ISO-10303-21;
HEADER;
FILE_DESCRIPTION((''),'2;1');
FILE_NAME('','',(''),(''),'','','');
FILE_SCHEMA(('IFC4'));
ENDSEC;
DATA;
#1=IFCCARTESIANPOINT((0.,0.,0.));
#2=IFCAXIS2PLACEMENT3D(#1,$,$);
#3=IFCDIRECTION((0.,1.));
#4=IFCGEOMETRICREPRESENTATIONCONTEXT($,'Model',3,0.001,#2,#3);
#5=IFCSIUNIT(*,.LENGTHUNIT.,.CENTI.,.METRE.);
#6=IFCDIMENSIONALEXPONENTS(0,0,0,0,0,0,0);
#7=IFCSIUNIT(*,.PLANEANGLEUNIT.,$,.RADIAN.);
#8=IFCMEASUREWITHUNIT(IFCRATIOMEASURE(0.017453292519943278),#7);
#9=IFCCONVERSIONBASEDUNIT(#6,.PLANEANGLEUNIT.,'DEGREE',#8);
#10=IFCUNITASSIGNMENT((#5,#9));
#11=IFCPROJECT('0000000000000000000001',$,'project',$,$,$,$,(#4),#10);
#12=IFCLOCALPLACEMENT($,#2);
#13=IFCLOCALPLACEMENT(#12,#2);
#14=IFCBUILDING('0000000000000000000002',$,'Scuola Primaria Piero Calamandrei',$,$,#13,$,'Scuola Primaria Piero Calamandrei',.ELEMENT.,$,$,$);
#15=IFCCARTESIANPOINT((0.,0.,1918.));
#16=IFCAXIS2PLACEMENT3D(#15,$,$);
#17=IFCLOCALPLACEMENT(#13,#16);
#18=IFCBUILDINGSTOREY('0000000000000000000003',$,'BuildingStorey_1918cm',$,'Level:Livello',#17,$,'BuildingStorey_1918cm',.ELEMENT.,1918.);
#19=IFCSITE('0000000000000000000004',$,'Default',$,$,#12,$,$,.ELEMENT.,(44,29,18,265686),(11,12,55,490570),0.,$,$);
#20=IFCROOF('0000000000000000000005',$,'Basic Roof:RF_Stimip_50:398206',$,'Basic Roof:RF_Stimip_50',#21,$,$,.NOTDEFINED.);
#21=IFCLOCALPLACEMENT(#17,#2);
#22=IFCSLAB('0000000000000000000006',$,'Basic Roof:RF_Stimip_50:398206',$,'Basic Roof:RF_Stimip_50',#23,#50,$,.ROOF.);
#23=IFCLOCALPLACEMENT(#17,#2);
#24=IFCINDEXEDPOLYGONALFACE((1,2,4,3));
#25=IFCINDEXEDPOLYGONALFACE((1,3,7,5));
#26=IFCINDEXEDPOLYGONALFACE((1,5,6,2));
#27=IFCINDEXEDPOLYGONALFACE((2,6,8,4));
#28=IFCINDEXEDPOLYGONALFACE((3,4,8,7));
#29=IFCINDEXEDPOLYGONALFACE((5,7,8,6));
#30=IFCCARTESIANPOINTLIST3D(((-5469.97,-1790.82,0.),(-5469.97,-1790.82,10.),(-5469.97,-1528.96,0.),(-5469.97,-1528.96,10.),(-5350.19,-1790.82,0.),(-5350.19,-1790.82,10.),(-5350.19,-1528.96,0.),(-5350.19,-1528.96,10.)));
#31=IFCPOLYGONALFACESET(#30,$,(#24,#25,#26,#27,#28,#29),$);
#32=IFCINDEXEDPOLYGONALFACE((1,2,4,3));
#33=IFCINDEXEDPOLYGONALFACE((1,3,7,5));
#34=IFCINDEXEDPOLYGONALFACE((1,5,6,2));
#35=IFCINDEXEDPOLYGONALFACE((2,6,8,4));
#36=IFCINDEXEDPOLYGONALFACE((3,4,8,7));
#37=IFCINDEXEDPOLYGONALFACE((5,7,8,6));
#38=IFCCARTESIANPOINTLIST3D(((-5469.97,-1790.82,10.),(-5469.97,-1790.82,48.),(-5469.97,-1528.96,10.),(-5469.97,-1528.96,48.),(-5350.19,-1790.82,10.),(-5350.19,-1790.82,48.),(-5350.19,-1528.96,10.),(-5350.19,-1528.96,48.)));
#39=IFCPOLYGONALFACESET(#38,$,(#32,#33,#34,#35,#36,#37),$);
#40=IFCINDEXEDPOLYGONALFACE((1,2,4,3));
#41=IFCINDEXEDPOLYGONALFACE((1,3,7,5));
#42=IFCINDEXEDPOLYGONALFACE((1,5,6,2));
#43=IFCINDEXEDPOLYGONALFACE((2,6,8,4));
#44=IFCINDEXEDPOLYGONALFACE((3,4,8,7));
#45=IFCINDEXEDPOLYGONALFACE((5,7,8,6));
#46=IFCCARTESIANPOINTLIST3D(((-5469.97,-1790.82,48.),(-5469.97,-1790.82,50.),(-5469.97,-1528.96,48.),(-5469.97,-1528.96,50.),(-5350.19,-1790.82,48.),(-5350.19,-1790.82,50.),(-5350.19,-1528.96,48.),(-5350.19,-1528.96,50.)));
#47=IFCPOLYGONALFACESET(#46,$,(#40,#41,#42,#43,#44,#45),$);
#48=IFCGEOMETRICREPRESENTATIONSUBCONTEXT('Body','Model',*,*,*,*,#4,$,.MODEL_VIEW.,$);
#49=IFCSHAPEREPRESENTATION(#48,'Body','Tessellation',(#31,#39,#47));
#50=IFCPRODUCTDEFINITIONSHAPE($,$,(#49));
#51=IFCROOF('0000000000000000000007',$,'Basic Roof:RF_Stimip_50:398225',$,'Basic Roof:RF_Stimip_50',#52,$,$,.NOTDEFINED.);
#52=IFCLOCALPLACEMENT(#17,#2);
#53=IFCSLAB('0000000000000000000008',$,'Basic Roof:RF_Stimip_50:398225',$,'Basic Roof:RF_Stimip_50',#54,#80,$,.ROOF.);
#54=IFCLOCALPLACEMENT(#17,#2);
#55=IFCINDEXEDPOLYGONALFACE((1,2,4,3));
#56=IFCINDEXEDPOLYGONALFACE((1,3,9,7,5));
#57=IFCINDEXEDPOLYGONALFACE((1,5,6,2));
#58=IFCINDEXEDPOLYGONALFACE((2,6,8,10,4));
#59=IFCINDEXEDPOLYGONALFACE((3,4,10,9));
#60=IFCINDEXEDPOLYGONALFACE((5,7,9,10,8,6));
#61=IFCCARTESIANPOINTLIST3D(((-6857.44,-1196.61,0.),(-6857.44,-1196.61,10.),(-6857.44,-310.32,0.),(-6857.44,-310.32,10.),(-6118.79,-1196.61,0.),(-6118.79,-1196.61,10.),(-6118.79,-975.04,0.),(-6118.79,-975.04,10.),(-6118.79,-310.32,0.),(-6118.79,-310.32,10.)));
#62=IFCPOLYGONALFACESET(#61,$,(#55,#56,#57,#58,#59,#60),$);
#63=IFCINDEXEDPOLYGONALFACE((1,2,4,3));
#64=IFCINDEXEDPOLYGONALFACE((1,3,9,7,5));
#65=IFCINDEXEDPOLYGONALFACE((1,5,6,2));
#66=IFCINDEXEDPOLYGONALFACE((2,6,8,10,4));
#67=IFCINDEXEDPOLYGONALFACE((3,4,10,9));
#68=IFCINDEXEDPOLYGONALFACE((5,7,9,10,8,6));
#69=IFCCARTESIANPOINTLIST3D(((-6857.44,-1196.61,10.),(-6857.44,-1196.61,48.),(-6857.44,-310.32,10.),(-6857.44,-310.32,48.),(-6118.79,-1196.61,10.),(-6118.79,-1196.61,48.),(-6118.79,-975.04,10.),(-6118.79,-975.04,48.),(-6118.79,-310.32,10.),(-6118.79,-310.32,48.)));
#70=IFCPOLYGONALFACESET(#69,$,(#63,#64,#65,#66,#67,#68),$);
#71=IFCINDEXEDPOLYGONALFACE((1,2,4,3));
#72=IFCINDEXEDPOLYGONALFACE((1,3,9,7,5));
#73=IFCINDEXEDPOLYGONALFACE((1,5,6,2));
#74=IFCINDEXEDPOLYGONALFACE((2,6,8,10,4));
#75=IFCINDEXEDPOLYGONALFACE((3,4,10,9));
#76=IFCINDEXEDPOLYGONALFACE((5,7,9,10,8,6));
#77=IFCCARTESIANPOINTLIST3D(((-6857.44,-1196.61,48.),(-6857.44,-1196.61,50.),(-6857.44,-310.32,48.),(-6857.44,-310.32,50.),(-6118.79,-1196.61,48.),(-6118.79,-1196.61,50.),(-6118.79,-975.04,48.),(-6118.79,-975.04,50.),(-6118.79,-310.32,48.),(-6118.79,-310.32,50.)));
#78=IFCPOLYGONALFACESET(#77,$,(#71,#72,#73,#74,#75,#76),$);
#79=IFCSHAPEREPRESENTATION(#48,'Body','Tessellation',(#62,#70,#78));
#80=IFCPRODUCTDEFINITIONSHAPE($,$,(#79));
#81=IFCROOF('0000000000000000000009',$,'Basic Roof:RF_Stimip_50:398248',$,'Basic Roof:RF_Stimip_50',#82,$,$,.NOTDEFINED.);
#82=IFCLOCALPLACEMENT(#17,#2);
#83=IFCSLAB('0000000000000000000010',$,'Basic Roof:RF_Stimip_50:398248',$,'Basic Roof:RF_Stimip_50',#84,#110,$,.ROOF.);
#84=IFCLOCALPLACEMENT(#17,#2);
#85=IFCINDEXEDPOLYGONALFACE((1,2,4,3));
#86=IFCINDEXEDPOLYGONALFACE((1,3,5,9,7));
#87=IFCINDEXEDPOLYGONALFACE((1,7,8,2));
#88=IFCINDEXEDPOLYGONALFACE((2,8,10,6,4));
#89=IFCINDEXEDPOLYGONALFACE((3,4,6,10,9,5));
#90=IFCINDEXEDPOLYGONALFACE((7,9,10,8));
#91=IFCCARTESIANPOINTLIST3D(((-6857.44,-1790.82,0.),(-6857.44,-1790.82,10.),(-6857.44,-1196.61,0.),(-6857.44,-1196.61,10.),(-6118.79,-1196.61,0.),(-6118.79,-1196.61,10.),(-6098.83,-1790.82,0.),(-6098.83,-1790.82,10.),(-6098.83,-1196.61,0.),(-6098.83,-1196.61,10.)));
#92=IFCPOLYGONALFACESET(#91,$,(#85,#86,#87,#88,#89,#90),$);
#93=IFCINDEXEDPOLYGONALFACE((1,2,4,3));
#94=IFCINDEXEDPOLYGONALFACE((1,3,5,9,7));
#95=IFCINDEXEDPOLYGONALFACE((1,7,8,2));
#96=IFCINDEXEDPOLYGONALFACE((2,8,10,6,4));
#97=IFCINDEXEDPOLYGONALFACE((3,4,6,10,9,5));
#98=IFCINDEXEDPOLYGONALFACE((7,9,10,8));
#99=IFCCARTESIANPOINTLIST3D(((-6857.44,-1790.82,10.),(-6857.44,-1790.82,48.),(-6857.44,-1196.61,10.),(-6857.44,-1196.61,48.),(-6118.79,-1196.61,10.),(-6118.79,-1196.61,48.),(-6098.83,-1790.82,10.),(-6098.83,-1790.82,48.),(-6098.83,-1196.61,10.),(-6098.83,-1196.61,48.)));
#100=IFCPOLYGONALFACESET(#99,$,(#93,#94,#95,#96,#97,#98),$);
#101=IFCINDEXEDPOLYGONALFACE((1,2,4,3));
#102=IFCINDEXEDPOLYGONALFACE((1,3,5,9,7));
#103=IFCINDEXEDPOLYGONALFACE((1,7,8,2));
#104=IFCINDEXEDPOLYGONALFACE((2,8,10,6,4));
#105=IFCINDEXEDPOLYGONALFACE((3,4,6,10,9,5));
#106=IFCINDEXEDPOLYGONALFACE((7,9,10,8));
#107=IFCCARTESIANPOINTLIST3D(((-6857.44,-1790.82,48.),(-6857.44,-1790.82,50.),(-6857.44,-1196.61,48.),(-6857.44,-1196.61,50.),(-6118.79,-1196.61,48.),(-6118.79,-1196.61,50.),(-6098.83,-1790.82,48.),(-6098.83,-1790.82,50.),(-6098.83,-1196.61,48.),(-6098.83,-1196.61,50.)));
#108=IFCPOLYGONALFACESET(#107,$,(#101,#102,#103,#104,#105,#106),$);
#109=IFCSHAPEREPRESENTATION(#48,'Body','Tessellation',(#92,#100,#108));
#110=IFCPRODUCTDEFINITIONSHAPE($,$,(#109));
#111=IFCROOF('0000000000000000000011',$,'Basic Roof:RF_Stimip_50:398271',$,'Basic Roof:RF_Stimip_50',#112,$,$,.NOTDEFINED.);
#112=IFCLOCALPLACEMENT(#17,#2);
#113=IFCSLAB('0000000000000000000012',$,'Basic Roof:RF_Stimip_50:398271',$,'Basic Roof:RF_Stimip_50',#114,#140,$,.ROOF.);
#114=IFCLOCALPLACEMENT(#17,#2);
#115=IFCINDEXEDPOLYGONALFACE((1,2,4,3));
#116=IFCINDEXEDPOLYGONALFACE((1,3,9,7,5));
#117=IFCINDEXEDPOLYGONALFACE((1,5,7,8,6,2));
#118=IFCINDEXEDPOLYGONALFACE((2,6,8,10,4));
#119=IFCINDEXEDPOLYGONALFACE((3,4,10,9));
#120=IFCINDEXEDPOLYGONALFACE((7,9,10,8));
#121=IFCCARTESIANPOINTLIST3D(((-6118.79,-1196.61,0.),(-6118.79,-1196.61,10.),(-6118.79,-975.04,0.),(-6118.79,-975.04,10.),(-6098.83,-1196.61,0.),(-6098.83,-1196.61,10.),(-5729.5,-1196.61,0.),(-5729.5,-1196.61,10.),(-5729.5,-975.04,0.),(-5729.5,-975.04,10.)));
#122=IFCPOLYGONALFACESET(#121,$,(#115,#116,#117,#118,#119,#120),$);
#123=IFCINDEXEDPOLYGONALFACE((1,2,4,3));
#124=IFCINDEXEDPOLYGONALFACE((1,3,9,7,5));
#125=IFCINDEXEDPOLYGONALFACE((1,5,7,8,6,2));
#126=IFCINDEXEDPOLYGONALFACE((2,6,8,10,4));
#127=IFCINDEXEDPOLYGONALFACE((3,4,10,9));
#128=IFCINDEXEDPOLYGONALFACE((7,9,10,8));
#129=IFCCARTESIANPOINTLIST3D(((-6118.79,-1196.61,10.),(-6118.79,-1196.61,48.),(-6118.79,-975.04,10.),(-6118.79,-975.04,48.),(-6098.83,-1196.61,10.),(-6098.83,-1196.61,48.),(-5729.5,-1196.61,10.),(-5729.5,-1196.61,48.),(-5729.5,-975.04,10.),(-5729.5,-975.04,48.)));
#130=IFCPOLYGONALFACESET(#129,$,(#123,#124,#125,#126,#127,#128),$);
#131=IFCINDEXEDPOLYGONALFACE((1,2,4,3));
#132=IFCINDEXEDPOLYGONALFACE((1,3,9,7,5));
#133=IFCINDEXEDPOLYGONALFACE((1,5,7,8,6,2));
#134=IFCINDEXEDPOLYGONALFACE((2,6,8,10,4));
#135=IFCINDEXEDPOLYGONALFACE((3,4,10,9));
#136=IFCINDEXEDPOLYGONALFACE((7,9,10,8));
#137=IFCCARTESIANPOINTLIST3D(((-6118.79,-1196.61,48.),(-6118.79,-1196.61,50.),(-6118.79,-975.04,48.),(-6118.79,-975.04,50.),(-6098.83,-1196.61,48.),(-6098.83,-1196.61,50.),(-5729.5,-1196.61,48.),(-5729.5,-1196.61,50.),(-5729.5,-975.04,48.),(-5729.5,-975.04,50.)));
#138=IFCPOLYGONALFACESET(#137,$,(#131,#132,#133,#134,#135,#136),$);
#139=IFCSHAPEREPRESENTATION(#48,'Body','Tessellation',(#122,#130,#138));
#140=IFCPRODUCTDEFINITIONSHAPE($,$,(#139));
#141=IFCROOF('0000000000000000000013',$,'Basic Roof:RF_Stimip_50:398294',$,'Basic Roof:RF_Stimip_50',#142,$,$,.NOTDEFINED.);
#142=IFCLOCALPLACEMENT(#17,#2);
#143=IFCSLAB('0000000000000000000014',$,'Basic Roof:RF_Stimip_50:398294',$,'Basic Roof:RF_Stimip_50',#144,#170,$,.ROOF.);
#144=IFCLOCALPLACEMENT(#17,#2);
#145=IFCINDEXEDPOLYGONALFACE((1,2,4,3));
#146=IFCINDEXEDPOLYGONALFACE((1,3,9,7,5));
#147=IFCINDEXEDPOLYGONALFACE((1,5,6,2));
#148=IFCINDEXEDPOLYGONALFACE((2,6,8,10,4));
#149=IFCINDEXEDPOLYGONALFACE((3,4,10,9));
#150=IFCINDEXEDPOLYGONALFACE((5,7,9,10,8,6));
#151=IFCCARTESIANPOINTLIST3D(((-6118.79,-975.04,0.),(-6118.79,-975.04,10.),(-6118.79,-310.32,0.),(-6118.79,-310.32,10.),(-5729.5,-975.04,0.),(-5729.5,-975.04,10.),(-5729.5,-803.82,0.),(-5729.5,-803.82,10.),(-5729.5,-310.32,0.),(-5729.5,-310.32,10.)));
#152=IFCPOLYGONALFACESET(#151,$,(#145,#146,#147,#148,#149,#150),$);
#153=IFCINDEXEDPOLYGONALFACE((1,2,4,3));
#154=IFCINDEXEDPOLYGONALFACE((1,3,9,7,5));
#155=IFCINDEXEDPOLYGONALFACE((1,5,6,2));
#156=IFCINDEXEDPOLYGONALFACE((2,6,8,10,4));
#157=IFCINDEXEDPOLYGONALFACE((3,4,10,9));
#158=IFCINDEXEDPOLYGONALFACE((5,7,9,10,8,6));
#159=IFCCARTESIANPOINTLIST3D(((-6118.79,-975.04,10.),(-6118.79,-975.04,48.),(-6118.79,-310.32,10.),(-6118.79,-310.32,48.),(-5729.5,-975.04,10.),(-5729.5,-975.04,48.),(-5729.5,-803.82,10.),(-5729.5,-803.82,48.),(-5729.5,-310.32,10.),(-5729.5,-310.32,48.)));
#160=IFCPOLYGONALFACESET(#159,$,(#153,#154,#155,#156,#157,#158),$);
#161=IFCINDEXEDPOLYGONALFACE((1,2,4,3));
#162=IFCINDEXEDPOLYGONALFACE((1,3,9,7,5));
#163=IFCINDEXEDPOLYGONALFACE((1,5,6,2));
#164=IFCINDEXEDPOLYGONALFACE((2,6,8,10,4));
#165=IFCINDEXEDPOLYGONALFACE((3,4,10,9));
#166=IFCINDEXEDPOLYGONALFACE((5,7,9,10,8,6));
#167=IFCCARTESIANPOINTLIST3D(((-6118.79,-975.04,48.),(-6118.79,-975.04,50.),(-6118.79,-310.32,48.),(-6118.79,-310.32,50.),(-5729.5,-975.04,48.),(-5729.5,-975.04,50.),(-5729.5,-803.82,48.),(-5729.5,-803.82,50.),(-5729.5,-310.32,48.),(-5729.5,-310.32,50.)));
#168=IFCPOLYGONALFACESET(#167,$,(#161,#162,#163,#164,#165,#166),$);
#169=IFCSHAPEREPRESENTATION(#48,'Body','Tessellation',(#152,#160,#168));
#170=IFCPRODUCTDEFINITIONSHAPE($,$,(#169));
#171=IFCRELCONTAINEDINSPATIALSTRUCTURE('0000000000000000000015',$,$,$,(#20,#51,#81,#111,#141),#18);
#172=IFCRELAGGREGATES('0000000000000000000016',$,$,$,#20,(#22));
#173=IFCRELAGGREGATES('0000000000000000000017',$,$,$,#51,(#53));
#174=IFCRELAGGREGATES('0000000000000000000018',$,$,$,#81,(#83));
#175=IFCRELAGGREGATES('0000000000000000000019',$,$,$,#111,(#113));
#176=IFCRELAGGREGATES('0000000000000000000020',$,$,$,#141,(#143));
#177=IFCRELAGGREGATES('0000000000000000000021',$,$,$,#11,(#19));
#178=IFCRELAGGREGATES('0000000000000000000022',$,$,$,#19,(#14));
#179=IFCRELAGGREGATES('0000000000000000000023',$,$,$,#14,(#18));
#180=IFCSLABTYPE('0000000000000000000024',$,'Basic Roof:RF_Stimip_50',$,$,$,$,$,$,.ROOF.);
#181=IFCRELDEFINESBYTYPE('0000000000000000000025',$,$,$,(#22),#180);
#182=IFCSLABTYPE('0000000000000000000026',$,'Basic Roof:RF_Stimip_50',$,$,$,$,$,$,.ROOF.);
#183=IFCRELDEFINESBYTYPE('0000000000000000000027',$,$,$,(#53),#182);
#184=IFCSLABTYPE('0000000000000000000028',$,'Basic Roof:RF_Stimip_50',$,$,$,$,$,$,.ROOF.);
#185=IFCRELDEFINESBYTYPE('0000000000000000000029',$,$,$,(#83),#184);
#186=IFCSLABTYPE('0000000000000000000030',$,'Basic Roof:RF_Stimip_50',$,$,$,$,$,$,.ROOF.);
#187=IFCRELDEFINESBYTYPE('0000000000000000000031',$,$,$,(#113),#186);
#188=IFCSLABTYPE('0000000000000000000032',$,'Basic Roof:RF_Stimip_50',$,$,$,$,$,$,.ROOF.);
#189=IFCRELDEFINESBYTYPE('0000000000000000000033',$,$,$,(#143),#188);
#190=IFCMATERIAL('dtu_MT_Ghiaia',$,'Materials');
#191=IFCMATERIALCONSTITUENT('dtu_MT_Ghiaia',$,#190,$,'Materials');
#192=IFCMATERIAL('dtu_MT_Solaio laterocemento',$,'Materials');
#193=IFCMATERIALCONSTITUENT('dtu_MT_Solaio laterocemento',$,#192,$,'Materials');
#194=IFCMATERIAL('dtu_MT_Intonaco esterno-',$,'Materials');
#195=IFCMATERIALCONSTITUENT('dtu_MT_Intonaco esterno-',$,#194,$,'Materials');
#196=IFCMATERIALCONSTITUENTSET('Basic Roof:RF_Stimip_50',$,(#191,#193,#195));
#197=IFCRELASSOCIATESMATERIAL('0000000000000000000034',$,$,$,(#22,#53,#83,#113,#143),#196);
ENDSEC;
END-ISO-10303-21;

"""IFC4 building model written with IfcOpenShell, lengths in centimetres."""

from ifc_helpers import new_model, entity, si_unit, converted_unit, direction, frame, origin, place, context, subcontext, project, spatial, indexed_curve, outline, extrude, material, constituent, constituent_set, type_object, element, aggregate, save


model = new_model("IFC4")

# Units and contexts
model_context = context("Model", 3, precision=0.001, world=origin(), true_north=direction((0.0, 1.0)))
body_context = subcontext(model_context, "Body", "Model", "MODEL_VIEW")
ifc_project = project(units=[si_unit("LENGTHUNIT", "METRE", prefix="CENTI"), converted_unit("PLANEANGLEUNIT", "DEGREE", entity("IfcRatioMeasure", 0.017453292519943278), si_unit("PLANEANGLEUNIT", "RADIAN"), dimensions=[0, 0, 0, 0, 0, 0, 0])], contexts=[model_context])

# Site, building, storey
site_placement = place(None, origin())
site = spatial("IfcSite", under=ifc_project, at=site_placement, Name="Default", CompositionType="ELEMENT", RefLatitude=(44, 29, 18, 265686), RefLongitude=(11, 12, 55, 490570), RefElevation=0.0)
building_placement = place(site_placement, origin())
building = spatial("IfcBuilding", under=site, at=building_placement, Name="Scuola Primaria Piero Calamandrei", LongName="Scuola Primaria Piero Calamandrei", CompositionType="ELEMENT")
storey_placement = place(building_placement, frame((0.0, 0.0, 1918.0)))
storey = spatial("IfcBuildingStorey", under=building, at=storey_placement, Name="BuildingStorey_1918cm", ObjectType="Level:Livello", LongName="BuildingStorey_1918cm", CompositionType="ELEMENT", Elevation=1918.0)

# Roofs, slabs
ifc_material_1 = material(Name="dtu_MT_Ghiaia", Category="Materials")
ifc_constituent_1 = constituent(ifc_material_1, Name="dtu_MT_Ghiaia", Category="Materials")
ifc_material_2 = material(Name="dtu_MT_Solaio laterocemento", Category="Materials")
ifc_constituent_2 = constituent(ifc_material_2, Name="dtu_MT_Solaio laterocemento", Category="Materials")
ifc_material_3 = material(Name="dtu_MT_Intonaco esterno-", Category="Materials")
ifc_constituent_3 = constituent(ifc_material_3, Name="dtu_MT_Intonaco esterno-", Category="Materials")
ifc_constituent_set = constituent_set(constituents=[ifc_constituent_1, ifc_constituent_2, ifc_constituent_3], Name="Basic Roof:RF_Stimip_50")
roof_1_placement = place(storey_placement, frame((-5469.97, -1790.82, 0.0)))
roof_1 = element("IfcRoof", 1, at=roof_1_placement, inside=storey, Name="Basic Roof:RF_Stimip_50:398206", ObjectType="Basic Roof:RF_Stimip_50", PredefinedType="NOTDEFINED")
slab_type_1 = type_object("IfcSlabType", Name="Basic Roof:RF_Stimip_50", PredefinedType="ROOF")
slab_1_placement = place(roof_1_placement, origin())
slab_1 = element("IfcSlab", 2, at=slab_1_placement, type_object=slab_type_1, material=ifc_constituent_set, Name="Basic Roof:RF_Stimip_50:398206", ObjectType="Basic Roof:RF_Stimip_50", PredefinedType="ROOF", context=body_context, shape_type="SweptSolid", body=[
    extrude(outline(indexed_curve([(59.89, -130.93), (59.89, 130.93), (-59.89, 130.93), (-59.89, -130.93), (59.89, -130.93)], self_intersect=False)), frame((59.89, 130.93, 0.0)), (0.0, 0.0, 1.0), 10.0),
    extrude(outline(indexed_curve([(59.89, -130.93), (59.89, 130.93), (-59.89, 130.93), (-59.89, -130.93), (59.89, -130.93)], self_intersect=False)), frame((59.89, 130.93, 10.0)), (0.0, 0.0, 1.0), 38.0),
    extrude(outline(indexed_curve([(59.89, -130.93), (59.89, 130.93), (-59.89, 130.93), (-59.89, -130.93), (59.89, -130.93)], self_intersect=False)), frame((59.89, 130.93, 48.0)), (0.0, 0.0, 1.0), 2.0),
])
aggregate(roof_1, [slab_1])
roof_2_placement = place(storey_placement, frame((-6857.44, -1196.61, 0.0)))
roof_2 = element("IfcRoof", 3, at=roof_2_placement, inside=storey, Name="Basic Roof:RF_Stimip_50:398225", ObjectType="Basic Roof:RF_Stimip_50", PredefinedType="NOTDEFINED")
slab_type_2 = type_object("IfcSlabType", Name="Basic Roof:RF_Stimip_50", PredefinedType="ROOF")
slab_2_placement = place(roof_2_placement, origin())
slab_2 = element("IfcSlab", 4, at=slab_2_placement, type_object=slab_type_2, material=ifc_constituent_set, Name="Basic Roof:RF_Stimip_50:398225", ObjectType="Basic Roof:RF_Stimip_50", PredefinedType="ROOF", context=body_context, shape_type="SweptSolid", body=[
    extrude(outline(indexed_curve([(-369.33, 443.14), (-369.33, -443.14), (369.33, -443.14), (369.33, -221.57), (369.33, 443.14), (-369.33, 443.14)], self_intersect=False)), frame((369.33, 443.14, 0.0)), (0.0, 0.0, 1.0), 10.0),
    extrude(outline(indexed_curve([(-369.33, 443.14), (-369.33, -443.14), (369.33, -443.14), (369.33, -221.57), (369.33, 443.14), (-369.33, 443.14)], self_intersect=False)), frame((369.33, 443.14, 10.0)), (0.0, 0.0, 1.0), 38.0),
    extrude(outline(indexed_curve([(-369.33, 443.14), (-369.33, -443.14), (369.33, -443.14), (369.33, -221.57), (369.33, 443.14), (-369.33, 443.14)], self_intersect=False)), frame((369.33, 443.14, 48.0)), (0.0, 0.0, 1.0), 2.0),
])
aggregate(roof_2, [slab_2])
roof_3_placement = place(storey_placement, frame((-6857.44, -1790.82, 0.0)))
roof_3 = element("IfcRoof", 5, at=roof_3_placement, inside=storey, Name="Basic Roof:RF_Stimip_50:398248", ObjectType="Basic Roof:RF_Stimip_50", PredefinedType="NOTDEFINED")
slab_type_3 = type_object("IfcSlabType", Name="Basic Roof:RF_Stimip_50", PredefinedType="ROOF")
slab_3_placement = place(roof_3_placement, origin())
slab_3 = element("IfcSlab", 6, at=slab_3_placement, type_object=slab_type_3, material=ifc_constituent_set, Name="Basic Roof:RF_Stimip_50:398248", ObjectType="Basic Roof:RF_Stimip_50", PredefinedType="ROOF", context=body_context, shape_type="SweptSolid", body=[
    extrude(outline(indexed_curve([(-379.31, -297.11), (379.31, -297.11), (379.31, 297.11), (359.35, 297.11), (-379.31, 297.11), (-379.31, -297.11)], self_intersect=False)), frame((379.31, 297.11, 0.0)), (0.0, 0.0, 1.0), 10.0),
    extrude(outline(indexed_curve([(-379.31, -297.11), (379.31, -297.11), (379.31, 297.11), (359.35, 297.11), (-379.31, 297.11), (-379.31, -297.11)], self_intersect=False)), frame((379.31, 297.11, 10.0)), (0.0, 0.0, 1.0), 38.0),
    extrude(outline(indexed_curve([(-379.31, -297.11), (379.31, -297.11), (379.31, 297.11), (359.35, 297.11), (-379.31, 297.11), (-379.31, -297.11)], self_intersect=False)), frame((379.31, 297.11, 48.0)), (0.0, 0.0, 1.0), 2.0),
])
aggregate(roof_3, [slab_3])
roof_4_placement = place(storey_placement, frame((-6118.79, -1196.61, 0.0)))
roof_4 = element("IfcRoof", 7, at=roof_4_placement, inside=storey, Name="Basic Roof:RF_Stimip_50:398271", ObjectType="Basic Roof:RF_Stimip_50", PredefinedType="NOTDEFINED")
slab_type_4 = type_object("IfcSlabType", Name="Basic Roof:RF_Stimip_50", PredefinedType="ROOF")
slab_4_placement = place(roof_4_placement, origin())
slab_4 = element("IfcSlab", 8, at=slab_4_placement, type_object=slab_type_4, material=ifc_constituent_set, Name="Basic Roof:RF_Stimip_50:398271", ObjectType="Basic Roof:RF_Stimip_50", PredefinedType="ROOF", context=body_context, shape_type="SweptSolid", body=[
    extrude(outline(indexed_curve([(-194.65, 110.79), (-194.65, -110.79), (-174.68, -110.79), (194.65, -110.79), (194.65, 110.79), (-194.65, 110.79)], self_intersect=False)), frame((194.65, 110.79, 0.0)), (0.0, 0.0, 1.0), 10.0),
    extrude(outline(indexed_curve([(-194.65, 110.79), (-194.65, -110.79), (-174.68, -110.79), (194.65, -110.79), (194.65, 110.79), (-194.65, 110.79)], self_intersect=False)), frame((194.65, 110.79, 10.0)), (0.0, 0.0, 1.0), 38.0),
    extrude(outline(indexed_curve([(-194.65, 110.79), (-194.65, -110.79), (-174.68, -110.79), (194.65, -110.79), (194.65, 110.79), (-194.65, 110.79)], self_intersect=False)), frame((194.65, 110.79, 48.0)), (0.0, 0.0, 1.0), 2.0),
])
aggregate(roof_4, [slab_4])
roof_5_placement = place(storey_placement, frame((-6118.79, -975.04, 0.0)))
roof_5 = element("IfcRoof", 9, at=roof_5_placement, inside=storey, Name="Basic Roof:RF_Stimip_50:398294", ObjectType="Basic Roof:RF_Stimip_50", PredefinedType="NOTDEFINED")
slab_type_5 = type_object("IfcSlabType", Name="Basic Roof:RF_Stimip_50", PredefinedType="ROOF")
slab_5_placement = place(roof_5_placement, origin())
slab_5 = element("IfcSlab", 10, at=slab_5_placement, type_object=slab_type_5, material=ifc_constituent_set, Name="Basic Roof:RF_Stimip_50:398294", ObjectType="Basic Roof:RF_Stimip_50", PredefinedType="ROOF", context=body_context, shape_type="SweptSolid", body=[
    extrude(outline(indexed_curve([(194.65, 332.36), (-194.65, 332.36), (-194.65, -332.36), (194.65, -332.36), (194.65, -161.14), (194.65, 332.36)], self_intersect=False)), frame((194.65, 332.36, 0.0)), (0.0, 0.0, 1.0), 10.0),
    extrude(outline(indexed_curve([(194.65, 332.36), (-194.65, 332.36), (-194.65, -332.36), (194.65, -332.36), (194.65, -161.14), (194.65, 332.36)], self_intersect=False)), frame((194.65, 332.36, 10.0)), (0.0, 0.0, 1.0), 38.0),
    extrude(outline(indexed_curve([(194.65, 332.36), (-194.65, 332.36), (-194.65, -332.36), (194.65, -332.36), (194.65, -161.14), (194.65, 332.36)], self_intersect=False)), frame((194.65, 332.36, 48.0)), (0.0, 0.0, 1.0), 2.0),
])
aggregate(roof_5, [slab_5])

save(model, "model.ifc")
